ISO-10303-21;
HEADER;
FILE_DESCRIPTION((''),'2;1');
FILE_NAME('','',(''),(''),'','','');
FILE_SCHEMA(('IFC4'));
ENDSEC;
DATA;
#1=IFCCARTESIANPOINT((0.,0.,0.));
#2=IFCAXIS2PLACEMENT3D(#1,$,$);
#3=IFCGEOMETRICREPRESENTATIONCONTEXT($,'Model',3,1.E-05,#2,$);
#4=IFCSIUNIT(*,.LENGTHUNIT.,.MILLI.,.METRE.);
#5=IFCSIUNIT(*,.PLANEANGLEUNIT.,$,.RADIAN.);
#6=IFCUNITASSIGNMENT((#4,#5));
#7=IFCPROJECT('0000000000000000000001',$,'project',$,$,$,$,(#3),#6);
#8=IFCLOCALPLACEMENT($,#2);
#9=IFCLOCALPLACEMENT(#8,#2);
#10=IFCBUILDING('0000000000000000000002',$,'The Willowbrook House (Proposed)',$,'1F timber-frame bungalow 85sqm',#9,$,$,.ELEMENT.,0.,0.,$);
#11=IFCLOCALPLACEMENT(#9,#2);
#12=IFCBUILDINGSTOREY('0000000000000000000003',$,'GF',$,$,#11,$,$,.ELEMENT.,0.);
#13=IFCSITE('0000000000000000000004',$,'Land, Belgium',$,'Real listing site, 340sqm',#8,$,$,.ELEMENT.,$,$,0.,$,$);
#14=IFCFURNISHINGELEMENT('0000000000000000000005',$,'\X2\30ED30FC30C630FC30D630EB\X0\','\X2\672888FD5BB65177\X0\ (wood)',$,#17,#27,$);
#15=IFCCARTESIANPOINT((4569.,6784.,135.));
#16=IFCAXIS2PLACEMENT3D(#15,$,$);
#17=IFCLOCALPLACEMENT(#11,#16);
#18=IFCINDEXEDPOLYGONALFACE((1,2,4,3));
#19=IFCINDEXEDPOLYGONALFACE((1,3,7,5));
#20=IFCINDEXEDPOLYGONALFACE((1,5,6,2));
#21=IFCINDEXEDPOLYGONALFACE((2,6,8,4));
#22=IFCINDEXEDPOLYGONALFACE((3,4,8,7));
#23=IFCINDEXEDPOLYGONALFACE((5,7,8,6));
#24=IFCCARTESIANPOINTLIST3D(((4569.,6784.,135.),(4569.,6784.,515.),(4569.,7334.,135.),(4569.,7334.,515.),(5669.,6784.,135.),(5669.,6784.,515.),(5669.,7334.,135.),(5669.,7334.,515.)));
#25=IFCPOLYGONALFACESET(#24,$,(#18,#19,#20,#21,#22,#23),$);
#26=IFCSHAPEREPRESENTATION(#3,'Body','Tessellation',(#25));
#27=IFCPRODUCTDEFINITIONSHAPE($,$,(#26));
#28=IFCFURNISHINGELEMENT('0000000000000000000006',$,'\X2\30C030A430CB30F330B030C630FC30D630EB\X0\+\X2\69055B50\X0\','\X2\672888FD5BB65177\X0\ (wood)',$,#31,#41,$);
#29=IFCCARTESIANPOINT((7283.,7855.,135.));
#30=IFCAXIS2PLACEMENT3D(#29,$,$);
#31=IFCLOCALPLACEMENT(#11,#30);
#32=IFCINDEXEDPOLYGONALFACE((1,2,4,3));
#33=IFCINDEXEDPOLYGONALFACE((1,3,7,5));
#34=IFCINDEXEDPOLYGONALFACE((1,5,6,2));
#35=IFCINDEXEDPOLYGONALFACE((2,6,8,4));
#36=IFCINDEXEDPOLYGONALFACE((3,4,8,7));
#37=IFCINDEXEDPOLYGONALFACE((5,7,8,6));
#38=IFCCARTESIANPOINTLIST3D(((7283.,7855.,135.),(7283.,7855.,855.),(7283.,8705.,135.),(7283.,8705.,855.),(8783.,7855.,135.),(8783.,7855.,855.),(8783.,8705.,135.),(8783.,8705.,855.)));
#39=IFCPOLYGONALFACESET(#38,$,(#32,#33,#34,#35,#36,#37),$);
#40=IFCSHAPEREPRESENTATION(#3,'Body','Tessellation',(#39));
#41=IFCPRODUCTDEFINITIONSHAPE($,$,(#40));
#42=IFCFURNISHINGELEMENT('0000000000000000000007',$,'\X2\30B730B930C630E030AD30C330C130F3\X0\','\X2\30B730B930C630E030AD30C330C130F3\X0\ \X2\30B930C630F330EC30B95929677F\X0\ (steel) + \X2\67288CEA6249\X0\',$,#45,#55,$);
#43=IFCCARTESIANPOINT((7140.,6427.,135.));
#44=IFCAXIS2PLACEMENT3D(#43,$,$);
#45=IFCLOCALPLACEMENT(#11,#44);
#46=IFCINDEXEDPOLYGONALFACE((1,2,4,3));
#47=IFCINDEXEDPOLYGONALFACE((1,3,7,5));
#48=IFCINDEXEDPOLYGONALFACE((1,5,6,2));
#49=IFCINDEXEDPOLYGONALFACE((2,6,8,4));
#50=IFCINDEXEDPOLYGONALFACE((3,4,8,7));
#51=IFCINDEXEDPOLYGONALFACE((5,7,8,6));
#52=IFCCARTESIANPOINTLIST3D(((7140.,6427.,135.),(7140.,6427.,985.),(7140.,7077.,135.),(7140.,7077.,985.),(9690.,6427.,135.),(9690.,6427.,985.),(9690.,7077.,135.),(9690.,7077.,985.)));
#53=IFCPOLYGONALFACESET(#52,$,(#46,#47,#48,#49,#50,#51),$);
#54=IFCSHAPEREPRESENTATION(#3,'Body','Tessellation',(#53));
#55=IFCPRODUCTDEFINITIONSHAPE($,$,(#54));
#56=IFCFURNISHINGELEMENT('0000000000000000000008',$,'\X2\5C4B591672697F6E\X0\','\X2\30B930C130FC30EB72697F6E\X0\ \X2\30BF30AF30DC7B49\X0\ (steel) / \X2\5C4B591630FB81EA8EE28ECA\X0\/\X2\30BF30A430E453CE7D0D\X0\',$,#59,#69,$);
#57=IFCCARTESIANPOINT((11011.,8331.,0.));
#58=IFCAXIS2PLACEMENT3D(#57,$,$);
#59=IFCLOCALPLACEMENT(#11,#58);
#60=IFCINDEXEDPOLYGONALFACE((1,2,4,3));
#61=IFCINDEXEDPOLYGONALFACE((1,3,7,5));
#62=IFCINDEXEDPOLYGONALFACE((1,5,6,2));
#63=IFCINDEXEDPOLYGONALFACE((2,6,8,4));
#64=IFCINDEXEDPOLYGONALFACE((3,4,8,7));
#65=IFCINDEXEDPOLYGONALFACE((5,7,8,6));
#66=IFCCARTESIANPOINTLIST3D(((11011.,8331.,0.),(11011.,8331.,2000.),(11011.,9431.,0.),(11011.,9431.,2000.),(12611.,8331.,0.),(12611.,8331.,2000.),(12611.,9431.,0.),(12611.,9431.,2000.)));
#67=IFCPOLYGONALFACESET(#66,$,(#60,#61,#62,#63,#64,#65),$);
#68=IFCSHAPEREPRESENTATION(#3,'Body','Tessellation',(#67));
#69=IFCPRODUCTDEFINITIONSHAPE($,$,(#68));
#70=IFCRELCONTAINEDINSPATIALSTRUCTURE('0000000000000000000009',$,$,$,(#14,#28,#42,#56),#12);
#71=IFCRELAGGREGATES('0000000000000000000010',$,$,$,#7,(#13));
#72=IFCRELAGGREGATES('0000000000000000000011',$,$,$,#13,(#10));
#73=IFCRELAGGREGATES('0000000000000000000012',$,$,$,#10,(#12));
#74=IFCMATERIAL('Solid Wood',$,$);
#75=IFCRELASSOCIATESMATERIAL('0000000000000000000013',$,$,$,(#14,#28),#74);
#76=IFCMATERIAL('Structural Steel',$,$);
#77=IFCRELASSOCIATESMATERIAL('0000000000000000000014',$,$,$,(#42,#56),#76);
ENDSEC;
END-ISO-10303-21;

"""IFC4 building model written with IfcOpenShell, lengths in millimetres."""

from ifc_helpers import new_model, si_unit, frame, frame_2d, origin, place, context, project, spatial, rectangle, extrude, material, element, save


model = new_model("IFC4")

# Units and contexts
model_context = context("Model", 3, precision=1e-05, world=origin())
ifc_project = project(units=[si_unit("LENGTHUNIT", "METRE", prefix="MILLI"), si_unit("PLANEANGLEUNIT", "RADIAN")], contexts=[model_context])

# Site, building, storey
site_placement = place(None, origin())
site = spatial("IfcSite", under=ifc_project, at=site_placement, Name="Land, Belgium", ObjectType="Real listing site, 340sqm", CompositionType="ELEMENT", RefElevation=0.0)
building_placement = place(site_placement, origin())
building = spatial("IfcBuilding", under=site, at=building_placement, Name="The Willowbrook House (Proposed)", ObjectType="1F timber-frame bungalow 85sqm", CompositionType="ELEMENT", ElevationOfRefHeight=0.0, ElevationOfTerrain=0.0)
storey_placement = place(building_placement, origin())
storey = spatial("IfcBuildingStorey", under=building, at=storey_placement, Name="GF", CompositionType="ELEMENT", Elevation=0.0)

# Shared definitions
ifc_material_1 = material(Name="Solid Wood")

# Shared definitions
ifc_material_2 = material(Name="Structural Steel")

# Furnishing elements
furnishing_1_placement = place(storey_placement, frame((4569.0, 6784.0, 135.0)))
element("IfcFurnishingElement", 1, at=furnishing_1_placement, inside=storey, material=ifc_material_1, Name="ローテーブル", Description="木製家具 (wood)", context=model_context, shape_type="SweptSolid", body=[
    extrude(rectangle(XDim=1100.0, YDim=550.0, at=frame_2d((550.0, 275.0))), frame((4569.0, 6784.0, 135.0)), (0.0, 0.0, 1.0), 380.0),
])
furnishing_2_placement = place(storey_placement, frame((7283.0, 7855.0, 135.0)))
element("IfcFurnishingElement", 2, at=furnishing_2_placement, inside=storey, material=ifc_material_1, Name="ダイニングテーブル+椅子", Description="木製家具 (wood)", context=model_context, shape_type="SweptSolid", body=[
    extrude(rectangle(XDim=1500.0, YDim=850.0, at=frame_2d((750.0, 425.0))), frame((7283.0, 7855.0, 135.0)), (0.0, 0.0, 1.0), 720.0),
])
furnishing_3_placement = place(storey_placement, frame((7140.0, 6427.0, 135.0)))
element("IfcFurnishingElement", 3, at=furnishing_3_placement, inside=storey, material=ifc_material_2, Name="システムキッチン", Description="システムキッチン ステンレス天板 (steel) + 木質扉", context=model_context, shape_type="SweptSolid", body=[
    extrude(rectangle(XDim=2550.0, YDim=650.0, at=frame_2d((1275.0, 325.0))), frame((7140.0, 6427.0, 135.0)), (0.0, 0.0, 1.0), 850.0),
])
furnishing_4_placement = place(storey_placement, frame((11011.0, 8331.0, 0.0)))
element("IfcFurnishingElement", 4, at=furnishing_4_placement, inside=storey, material=ifc_material_2, Name="屋外物置", Description="スチール物置 タクボ等 (steel) / 屋外・自転車/タイヤ収納", context=model_context, shape_type="SweptSolid", body=[
    extrude(rectangle(XDim=1600.0, YDim=1100.0, at=frame_2d((800.0, 550.0))), frame((11011.0, 8331.0, 0.0)), (0.0, 0.0, 1.0), 2000.0),
])

save(model, "model.ifc")
